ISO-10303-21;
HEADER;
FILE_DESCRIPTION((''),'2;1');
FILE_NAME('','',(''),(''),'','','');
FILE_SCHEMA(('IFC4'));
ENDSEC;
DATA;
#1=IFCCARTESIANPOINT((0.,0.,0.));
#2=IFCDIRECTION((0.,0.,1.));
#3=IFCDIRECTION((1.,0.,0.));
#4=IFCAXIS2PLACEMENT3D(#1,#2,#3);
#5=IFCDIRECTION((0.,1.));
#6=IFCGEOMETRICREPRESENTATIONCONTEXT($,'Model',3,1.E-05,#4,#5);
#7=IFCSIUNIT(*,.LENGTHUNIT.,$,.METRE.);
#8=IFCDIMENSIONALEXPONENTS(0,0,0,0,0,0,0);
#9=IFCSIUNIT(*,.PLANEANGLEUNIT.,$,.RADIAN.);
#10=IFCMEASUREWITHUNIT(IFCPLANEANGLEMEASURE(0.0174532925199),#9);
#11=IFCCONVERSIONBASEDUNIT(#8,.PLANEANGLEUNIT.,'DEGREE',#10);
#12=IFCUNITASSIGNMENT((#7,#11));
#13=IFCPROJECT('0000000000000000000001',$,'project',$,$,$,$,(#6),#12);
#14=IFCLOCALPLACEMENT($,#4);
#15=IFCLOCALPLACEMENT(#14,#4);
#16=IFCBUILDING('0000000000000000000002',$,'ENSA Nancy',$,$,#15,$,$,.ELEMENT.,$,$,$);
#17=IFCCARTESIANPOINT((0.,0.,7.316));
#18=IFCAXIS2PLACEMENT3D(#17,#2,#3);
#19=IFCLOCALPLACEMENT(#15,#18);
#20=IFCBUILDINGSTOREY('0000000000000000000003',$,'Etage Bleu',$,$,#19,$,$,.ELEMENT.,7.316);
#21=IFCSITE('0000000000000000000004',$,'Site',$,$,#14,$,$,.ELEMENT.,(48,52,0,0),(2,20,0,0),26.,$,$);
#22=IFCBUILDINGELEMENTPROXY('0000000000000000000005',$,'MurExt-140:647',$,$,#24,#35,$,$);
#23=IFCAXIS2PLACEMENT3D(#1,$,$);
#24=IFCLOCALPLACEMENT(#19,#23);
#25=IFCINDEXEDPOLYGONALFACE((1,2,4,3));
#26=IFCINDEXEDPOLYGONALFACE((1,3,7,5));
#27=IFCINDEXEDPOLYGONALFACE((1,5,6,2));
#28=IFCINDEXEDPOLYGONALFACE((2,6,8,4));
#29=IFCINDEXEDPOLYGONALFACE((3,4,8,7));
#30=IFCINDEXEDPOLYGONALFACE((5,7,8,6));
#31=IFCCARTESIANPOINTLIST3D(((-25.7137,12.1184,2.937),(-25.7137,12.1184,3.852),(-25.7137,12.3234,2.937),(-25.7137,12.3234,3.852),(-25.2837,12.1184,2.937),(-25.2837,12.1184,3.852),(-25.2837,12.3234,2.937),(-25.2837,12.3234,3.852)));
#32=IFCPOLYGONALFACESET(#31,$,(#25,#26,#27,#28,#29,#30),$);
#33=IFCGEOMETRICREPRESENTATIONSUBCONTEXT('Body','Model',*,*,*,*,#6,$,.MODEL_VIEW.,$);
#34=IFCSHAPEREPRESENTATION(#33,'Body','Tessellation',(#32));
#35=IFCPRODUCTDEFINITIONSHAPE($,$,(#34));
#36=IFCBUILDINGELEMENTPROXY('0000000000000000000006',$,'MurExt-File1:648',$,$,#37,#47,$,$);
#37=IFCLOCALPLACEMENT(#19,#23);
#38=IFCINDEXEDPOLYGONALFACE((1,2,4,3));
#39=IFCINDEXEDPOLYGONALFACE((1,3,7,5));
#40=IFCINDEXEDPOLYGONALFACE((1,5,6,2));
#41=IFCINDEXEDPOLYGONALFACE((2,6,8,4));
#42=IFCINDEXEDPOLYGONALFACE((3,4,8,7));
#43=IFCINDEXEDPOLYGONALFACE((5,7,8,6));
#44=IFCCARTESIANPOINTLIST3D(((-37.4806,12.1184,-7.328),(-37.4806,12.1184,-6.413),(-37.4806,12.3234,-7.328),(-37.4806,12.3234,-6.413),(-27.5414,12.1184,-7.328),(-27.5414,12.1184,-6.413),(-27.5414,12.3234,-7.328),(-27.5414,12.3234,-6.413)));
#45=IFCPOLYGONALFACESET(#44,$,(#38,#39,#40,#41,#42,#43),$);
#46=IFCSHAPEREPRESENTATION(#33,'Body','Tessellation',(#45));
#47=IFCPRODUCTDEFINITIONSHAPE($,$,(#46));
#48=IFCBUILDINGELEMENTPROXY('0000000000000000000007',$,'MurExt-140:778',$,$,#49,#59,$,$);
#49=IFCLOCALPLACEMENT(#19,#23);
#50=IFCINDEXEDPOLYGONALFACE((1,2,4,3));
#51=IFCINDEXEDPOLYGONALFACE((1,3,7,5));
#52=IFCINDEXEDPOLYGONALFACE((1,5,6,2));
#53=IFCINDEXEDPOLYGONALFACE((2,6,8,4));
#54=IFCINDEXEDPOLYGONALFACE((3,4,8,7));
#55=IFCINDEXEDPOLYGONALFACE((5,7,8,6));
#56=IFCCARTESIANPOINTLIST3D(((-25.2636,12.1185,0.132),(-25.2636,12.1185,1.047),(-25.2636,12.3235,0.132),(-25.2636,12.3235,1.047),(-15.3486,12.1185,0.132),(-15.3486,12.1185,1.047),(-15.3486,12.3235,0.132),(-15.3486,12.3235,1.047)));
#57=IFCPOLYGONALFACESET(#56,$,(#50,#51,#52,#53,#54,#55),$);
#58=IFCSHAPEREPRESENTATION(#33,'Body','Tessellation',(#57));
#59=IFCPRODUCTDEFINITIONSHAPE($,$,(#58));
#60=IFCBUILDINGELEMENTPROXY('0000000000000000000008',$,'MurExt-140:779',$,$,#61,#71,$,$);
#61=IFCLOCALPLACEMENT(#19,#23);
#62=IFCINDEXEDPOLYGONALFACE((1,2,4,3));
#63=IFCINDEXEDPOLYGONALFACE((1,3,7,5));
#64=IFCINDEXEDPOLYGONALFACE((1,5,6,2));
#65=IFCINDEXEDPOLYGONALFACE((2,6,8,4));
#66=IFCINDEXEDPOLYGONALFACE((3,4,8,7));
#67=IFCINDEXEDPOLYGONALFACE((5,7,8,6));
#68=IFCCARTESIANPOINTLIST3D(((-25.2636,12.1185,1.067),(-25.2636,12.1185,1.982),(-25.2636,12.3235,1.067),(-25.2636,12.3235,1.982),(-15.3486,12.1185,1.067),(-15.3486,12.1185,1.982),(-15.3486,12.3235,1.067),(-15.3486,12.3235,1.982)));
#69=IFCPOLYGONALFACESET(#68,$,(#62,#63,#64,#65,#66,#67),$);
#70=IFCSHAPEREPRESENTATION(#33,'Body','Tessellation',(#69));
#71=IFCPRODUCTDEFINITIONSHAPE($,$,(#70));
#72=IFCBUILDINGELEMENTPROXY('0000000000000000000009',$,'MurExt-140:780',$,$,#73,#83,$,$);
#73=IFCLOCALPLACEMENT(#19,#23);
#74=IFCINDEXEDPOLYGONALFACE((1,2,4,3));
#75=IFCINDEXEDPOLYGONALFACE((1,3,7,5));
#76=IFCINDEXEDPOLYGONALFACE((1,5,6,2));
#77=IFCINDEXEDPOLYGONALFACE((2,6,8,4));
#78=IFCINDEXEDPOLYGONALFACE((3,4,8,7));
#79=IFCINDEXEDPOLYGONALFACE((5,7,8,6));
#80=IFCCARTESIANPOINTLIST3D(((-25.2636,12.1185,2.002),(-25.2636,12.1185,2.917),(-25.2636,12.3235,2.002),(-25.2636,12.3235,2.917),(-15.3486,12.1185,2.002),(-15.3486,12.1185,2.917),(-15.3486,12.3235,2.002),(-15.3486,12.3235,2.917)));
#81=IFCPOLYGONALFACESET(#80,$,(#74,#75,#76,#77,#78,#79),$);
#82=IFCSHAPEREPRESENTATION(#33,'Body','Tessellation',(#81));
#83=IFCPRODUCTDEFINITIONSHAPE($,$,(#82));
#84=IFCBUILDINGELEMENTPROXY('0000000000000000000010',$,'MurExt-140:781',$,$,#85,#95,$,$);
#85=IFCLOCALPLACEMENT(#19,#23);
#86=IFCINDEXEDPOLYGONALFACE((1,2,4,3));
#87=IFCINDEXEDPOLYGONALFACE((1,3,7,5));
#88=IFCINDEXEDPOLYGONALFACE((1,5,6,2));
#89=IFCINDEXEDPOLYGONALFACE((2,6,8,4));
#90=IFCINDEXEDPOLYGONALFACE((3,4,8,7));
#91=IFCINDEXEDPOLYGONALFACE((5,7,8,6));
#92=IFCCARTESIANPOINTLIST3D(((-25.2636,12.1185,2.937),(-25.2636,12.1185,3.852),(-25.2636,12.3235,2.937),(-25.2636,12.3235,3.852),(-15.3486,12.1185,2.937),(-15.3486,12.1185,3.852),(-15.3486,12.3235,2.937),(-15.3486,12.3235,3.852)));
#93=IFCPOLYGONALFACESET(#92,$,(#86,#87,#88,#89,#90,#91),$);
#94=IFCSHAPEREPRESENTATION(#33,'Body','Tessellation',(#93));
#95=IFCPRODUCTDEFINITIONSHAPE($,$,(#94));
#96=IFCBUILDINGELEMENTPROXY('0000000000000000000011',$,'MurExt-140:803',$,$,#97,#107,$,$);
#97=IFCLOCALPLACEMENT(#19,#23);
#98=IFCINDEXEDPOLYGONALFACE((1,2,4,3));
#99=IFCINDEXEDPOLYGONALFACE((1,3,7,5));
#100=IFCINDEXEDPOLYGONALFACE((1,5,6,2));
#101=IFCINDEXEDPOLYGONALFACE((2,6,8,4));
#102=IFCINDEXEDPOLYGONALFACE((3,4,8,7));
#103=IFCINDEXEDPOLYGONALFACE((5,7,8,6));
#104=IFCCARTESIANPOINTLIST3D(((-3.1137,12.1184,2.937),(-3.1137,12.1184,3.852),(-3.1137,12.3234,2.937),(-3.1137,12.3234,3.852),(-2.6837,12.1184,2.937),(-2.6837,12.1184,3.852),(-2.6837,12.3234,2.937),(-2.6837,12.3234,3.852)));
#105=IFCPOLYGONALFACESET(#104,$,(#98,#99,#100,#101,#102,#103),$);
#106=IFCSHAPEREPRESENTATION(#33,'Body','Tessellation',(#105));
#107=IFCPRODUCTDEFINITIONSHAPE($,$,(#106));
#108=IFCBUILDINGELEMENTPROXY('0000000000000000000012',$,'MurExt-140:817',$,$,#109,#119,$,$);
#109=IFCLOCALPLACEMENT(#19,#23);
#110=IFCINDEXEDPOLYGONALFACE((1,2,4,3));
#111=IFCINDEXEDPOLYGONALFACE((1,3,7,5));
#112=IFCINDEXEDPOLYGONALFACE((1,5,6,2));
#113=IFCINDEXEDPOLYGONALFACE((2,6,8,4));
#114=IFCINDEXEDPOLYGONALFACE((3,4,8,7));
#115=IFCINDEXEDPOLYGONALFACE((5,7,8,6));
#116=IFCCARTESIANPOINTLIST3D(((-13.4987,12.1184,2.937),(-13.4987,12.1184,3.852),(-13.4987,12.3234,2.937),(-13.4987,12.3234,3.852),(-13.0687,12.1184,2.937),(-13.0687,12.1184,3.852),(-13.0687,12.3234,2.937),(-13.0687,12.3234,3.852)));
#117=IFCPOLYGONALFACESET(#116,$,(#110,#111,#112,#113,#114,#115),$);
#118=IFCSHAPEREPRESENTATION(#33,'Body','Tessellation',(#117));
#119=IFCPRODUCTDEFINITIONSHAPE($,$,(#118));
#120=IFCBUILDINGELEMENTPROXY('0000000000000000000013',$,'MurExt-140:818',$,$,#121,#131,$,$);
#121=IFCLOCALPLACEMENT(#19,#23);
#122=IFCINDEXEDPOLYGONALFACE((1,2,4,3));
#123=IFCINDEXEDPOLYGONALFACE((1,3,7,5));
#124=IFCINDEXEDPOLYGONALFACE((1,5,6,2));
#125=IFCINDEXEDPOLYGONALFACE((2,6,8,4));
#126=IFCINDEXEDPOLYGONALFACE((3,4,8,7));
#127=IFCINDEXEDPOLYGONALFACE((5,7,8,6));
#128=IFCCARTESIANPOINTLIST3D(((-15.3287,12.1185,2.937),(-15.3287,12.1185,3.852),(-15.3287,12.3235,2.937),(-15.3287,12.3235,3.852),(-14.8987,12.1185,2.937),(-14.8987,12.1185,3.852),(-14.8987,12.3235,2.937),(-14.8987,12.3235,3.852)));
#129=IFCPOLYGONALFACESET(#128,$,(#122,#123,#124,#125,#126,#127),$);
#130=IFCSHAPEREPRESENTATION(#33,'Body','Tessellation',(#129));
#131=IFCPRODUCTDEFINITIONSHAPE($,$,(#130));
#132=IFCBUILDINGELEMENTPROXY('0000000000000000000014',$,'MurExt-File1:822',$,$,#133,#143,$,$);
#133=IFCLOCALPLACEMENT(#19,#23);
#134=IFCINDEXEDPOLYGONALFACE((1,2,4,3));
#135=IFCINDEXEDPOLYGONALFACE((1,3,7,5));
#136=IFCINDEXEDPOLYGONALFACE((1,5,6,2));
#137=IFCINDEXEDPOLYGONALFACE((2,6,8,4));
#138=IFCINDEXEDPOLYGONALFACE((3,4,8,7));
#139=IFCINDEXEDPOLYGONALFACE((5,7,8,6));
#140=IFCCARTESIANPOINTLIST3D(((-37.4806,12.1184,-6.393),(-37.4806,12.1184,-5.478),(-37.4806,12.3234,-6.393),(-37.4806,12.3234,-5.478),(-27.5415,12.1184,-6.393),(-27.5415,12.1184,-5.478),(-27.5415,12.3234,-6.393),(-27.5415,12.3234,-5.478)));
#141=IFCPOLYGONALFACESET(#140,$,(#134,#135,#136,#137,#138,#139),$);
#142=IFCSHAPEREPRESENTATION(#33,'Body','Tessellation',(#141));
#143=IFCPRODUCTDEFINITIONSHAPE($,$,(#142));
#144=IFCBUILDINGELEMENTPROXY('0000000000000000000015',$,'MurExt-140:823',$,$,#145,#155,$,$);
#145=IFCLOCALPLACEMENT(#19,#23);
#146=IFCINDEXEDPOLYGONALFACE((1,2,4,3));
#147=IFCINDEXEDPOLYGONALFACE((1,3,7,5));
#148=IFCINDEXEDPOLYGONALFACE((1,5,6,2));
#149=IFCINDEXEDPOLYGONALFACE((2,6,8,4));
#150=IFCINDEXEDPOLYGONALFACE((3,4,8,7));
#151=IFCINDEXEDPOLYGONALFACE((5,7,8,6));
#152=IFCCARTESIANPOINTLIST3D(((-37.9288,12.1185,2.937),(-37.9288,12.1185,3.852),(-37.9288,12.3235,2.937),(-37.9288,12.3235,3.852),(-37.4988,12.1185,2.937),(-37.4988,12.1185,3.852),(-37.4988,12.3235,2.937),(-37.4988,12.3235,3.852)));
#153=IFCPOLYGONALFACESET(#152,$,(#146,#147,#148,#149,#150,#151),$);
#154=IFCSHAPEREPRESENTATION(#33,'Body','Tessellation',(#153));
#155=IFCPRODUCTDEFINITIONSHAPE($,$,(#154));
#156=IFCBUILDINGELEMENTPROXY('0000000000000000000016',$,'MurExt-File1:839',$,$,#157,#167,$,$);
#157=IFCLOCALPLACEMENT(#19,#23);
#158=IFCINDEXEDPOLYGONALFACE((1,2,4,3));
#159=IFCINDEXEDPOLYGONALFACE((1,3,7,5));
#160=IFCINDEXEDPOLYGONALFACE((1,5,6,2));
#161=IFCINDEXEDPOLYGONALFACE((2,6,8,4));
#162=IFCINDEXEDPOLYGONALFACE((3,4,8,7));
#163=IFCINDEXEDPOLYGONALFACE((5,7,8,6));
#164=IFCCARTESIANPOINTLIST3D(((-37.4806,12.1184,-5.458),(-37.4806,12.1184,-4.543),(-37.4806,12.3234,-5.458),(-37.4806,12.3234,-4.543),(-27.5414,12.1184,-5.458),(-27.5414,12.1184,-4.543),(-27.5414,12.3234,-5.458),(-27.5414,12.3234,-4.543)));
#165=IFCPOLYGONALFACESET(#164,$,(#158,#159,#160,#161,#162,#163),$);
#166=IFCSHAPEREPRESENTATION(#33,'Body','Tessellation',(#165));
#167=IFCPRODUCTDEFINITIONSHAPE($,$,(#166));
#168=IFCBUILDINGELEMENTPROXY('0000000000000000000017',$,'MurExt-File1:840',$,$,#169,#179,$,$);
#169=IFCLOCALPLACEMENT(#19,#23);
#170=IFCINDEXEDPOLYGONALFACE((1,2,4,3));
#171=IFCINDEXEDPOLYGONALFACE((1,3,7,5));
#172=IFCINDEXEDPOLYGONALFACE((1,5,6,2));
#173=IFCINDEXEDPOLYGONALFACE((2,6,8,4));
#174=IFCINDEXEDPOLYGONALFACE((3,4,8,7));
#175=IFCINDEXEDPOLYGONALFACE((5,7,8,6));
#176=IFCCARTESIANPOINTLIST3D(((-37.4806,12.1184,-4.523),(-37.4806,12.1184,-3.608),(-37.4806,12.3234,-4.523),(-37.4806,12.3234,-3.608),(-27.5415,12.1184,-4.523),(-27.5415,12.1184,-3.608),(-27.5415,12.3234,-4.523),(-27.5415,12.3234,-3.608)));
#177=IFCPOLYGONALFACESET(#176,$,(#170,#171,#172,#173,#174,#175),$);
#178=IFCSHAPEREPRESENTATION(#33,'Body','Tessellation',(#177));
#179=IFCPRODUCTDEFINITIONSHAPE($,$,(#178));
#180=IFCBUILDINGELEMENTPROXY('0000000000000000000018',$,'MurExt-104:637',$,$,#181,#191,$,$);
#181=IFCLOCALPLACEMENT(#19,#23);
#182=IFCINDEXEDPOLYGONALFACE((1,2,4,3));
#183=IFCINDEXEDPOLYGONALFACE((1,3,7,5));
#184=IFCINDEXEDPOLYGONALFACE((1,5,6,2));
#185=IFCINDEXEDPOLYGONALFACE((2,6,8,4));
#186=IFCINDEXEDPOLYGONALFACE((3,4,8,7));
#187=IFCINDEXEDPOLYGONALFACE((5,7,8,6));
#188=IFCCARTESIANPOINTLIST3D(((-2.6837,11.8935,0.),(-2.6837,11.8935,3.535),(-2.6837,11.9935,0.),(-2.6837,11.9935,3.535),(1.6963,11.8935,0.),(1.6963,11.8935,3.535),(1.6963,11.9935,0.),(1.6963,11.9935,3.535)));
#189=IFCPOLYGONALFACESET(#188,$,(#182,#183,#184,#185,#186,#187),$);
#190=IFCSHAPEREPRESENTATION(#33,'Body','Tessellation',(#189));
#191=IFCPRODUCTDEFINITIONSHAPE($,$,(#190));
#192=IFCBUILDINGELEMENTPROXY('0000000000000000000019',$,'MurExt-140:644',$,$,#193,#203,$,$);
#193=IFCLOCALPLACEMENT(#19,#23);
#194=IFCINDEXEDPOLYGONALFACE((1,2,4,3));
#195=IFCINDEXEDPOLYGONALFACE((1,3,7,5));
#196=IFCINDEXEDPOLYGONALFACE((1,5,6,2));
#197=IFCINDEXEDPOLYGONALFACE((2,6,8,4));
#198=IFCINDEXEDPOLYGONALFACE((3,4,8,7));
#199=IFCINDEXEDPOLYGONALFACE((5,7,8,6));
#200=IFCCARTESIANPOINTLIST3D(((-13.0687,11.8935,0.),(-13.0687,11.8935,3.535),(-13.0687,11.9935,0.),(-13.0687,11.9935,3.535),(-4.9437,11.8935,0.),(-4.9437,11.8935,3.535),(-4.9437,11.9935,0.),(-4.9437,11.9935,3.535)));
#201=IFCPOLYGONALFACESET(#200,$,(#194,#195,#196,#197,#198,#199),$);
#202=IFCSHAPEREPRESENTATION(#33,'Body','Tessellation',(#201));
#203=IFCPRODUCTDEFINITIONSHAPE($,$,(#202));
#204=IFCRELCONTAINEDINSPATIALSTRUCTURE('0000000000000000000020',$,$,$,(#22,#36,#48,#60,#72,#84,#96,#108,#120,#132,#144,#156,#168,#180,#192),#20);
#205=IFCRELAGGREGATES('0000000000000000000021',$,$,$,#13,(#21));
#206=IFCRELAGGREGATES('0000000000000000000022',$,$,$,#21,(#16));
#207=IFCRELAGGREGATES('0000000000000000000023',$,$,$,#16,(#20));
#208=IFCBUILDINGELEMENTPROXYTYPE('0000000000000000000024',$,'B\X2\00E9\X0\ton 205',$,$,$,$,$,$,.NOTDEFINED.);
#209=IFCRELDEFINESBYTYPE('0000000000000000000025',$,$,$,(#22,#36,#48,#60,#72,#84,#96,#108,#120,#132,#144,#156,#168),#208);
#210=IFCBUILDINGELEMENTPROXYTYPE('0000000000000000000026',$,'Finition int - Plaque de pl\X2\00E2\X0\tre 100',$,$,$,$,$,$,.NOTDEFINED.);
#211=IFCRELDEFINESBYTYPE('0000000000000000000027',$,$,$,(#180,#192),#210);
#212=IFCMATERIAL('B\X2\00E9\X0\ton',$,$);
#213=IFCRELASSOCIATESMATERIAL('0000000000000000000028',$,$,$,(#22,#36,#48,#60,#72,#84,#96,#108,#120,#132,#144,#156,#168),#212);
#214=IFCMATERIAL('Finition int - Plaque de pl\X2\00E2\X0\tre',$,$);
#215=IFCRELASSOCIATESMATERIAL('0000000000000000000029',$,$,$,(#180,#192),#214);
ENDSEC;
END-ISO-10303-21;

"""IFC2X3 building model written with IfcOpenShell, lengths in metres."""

from ifc_helpers import new_model, entity, si_unit, converted_unit, direction, frame, origin_with_axes, place, context, subcontext, project, spatial, polyline, outline, extrude, material, type_object, element, save


model = new_model("IFC2X3")

# Units and contexts
model_context = context("Model", 3, precision=1e-05, world=origin_with_axes(), true_north=direction((0.0, 1.0)))
body_context = subcontext(model_context, "Body", "Model", "MODEL_VIEW")
ifc_project = project(units=[si_unit("LENGTHUNIT", "METRE"), converted_unit("PLANEANGLEUNIT", "DEGREE", entity("IfcPlaneAngleMeasure", 0.0174532925199), si_unit("PLANEANGLEUNIT", "RADIAN"), dimensions=[0, 0, 0, 0, 0, 0, 0])], contexts=[model_context])

# Site, building, storey
site_placement = place(None, origin_with_axes())
site = spatial("IfcSite", under=ifc_project, at=site_placement, Name="Site", CompositionType="ELEMENT", RefLatitude=(48, 52, 0, 0), RefLongitude=(2, 20, 0, 0), RefElevation=26.0)
building_placement = place(site_placement, origin_with_axes())
building = spatial("IfcBuilding", under=site, at=building_placement, Name="ENSA Nancy", CompositionType="ELEMENT")
storey_placement = place(building_placement, frame((0.0, 0.0, 7.316), z_axis=(0.0, 0.0, 1.0), x_axis=(1.0, 0.0, 0.0)))
storey = spatial("IfcBuildingStorey", under=building, at=storey_placement, Name="Etage Bleu", CompositionType="ELEMENT", Elevation=7.316)

# Shared definitions
ifc_material_1 = material(Name="Finition int - Plaque de plâtre")

# Shared definitions
ifc_material_2 = material(Name="Béton")

# Building element proxies
building_element_proxy_type_1 = type_object("IfcBuildingElementProxyType", Name="Béton 205", PredefinedType="NOTDEFINED")
for number, where, z_axis, x_axis, name in (
    (1, (-25.7137, 12.3234, 2.937), (0.0, 0.0, 1.0), (1.0, 0.0, 0.0), "MurExt-140:647"),
):
    element("IfcBuildingElementProxy", number, at=place(storey_placement, frame(where, z_axis=z_axis, x_axis=x_axis)), inside=storey, type_object=building_element_proxy_type_1, material=ifc_material_2, Name=name, context=body_context, shape_type="SweptSolid", body=[
        extrude(outline(polyline([(0.0, -0.205), (0.43, -0.205), (0.43, 0.0), (0.0, 0.0), (0.0, -0.205)])), origin_with_axes(), (0.0, 0.0, 1.0), 0.915),
    ])
proxy_1_placement = place(storey_placement, frame((-37.4806, 12.3234, -7.328), z_axis=(0.0, 0.0, 1.0), x_axis=(1.0, -0.000005, 0.0)))
element("IfcBuildingElementProxy", 2, at=proxy_1_placement, inside=storey, type_object=building_element_proxy_type_1, material=ifc_material_2, Name="MurExt-File1:648", context=body_context, shape_type="SweptSolid", body=[
    extrude(outline(polyline([(0.0, -0.205), (9.9392, -0.205), (9.9392, 0.0), (0.0, 0.0), (0.0, -0.205)])), origin_with_axes(), (0.0, 0.0, 1.0), 0.915),
])
for number, where, z_axis, x_axis, name in (
    (3, (-25.2636, 12.3235, 0.132), (0.0, 0.0, 1.0), (1.0, 0.0, 0.0), "MurExt-140:778"),
    (4, (-25.2636, 12.3235, 1.067), (0.0, 0.0, 1.0), (1.0, 0.0, 0.0), "MurExt-140:779"),
    (5, (-25.2636, 12.3235, 2.002), (0.0, 0.0, 1.0), (1.0, 0.0, 0.0), "MurExt-140:780"),
    (6, (-25.2636, 12.3235, 2.937), (0.0, 0.0, 1.0), (1.0, 0.0, 0.0), "MurExt-140:781"),
):
    element("IfcBuildingElementProxy", number, at=place(storey_placement, frame(where, z_axis=z_axis, x_axis=x_axis)), inside=storey, type_object=building_element_proxy_type_1, material=ifc_material_2, Name=name, context=body_context, shape_type="SweptSolid", body=[
        extrude(outline(polyline([(0.0, -0.205), (9.915, -0.205), (9.915, 0.0), (0.0, 0.0), (0.0, -0.205)])), origin_with_axes(), (0.0, 0.0, 1.0), 0.915),
    ])
for number, where, z_axis, x_axis, name in (
    (7, (-3.1137, 12.3234, 2.937), (0.0, 0.0, 1.0), (1.0, 0.0, 0.0), "MurExt-140:803"),
    (8, (-13.4987, 12.3234, 2.937), (0.0, 0.0, 1.0), (1.0, 0.0, 0.0), "MurExt-140:817"),
    (9, (-15.3287, 12.3235, 2.937), (0.0, 0.0, 1.0), (1.0, 0.0, 0.0), "MurExt-140:818"),
):
    element("IfcBuildingElementProxy", number, at=place(storey_placement, frame(where, z_axis=z_axis, x_axis=x_axis)), inside=storey, type_object=building_element_proxy_type_1, material=ifc_material_2, Name=name, context=body_context, shape_type="SweptSolid", body=[
        extrude(outline(polyline([(0.0, -0.205), (0.43, -0.205), (0.43, 0.0), (0.0, 0.0), (0.0, -0.205)])), origin_with_axes(), (0.0, 0.0, 1.0), 0.915),
    ])
proxy_2_placement = place(storey_placement, frame((-37.4806, 12.3234, -6.393), z_axis=(0.0, 0.0, 1.0), x_axis=(1.0, -0.000005, 0.0)))
element("IfcBuildingElementProxy", 10, at=proxy_2_placement, inside=storey, type_object=building_element_proxy_type_1, material=ifc_material_2, Name="MurExt-File1:822", context=body_context, shape_type="SweptSolid", body=[
    extrude(outline(polyline([(0.0, -0.205), (9.9392, -0.205), (9.9392, 0.0), (0.0, 0.0), (0.0, -0.205)])), origin_with_axes(), (0.0, 0.0, 1.0), 0.915),
])
proxy_3_placement = place(storey_placement, frame((-37.9288, 12.3235, 2.937), z_axis=(0.0, 0.0, 1.0), x_axis=(1.0, 0.0, 0.0)))
element("IfcBuildingElementProxy", 11, at=proxy_3_placement, inside=storey, type_object=building_element_proxy_type_1, material=ifc_material_2, Name="MurExt-140:823", context=body_context, shape_type="SweptSolid", body=[
    extrude(outline(polyline([(0.0, -0.205), (0.43, -0.205), (0.43, 0.0), (0.0, 0.0), (0.0, -0.205)])), origin_with_axes(), (0.0, 0.0, 1.0), 0.915),
])
for number, where, z_axis, x_axis, name in (
    (12, (-37.4806, 12.3234, -5.458), (0.0, 0.0, 1.0), (1.0, -0.000005, 0.0), "MurExt-File1:839"),
    (13, (-37.4806, 12.3234, -4.523), (0.0, 0.0, 1.0), (1.0, -0.000005, 0.0), "MurExt-File1:840"),
):
    element("IfcBuildingElementProxy", number, at=place(storey_placement, frame(where, z_axis=z_axis, x_axis=x_axis)), inside=storey, type_object=building_element_proxy_type_1, material=ifc_material_2, Name=name, context=body_context, shape_type="SweptSolid", body=[
        extrude(outline(polyline([(0.0, -0.205), (9.9392, -0.205), (9.9392, 0.0), (0.0, 0.0), (0.0, -0.205)])), origin_with_axes(), (0.0, 0.0, 1.0), 0.915),
    ])
building_element_proxy_type_2 = type_object("IfcBuildingElementProxyType", Name="Finition int - Plaque de plâtre 100", PredefinedType="NOTDEFINED")
proxy_4_placement = place(storey_placement, frame((-2.6837, 11.8935, 0.0), z_axis=(0.0, 0.0, 1.0), x_axis=(1.0, 0.0, 0.0)))
element("IfcBuildingElementProxy", 14, at=proxy_4_placement, inside=storey, type_object=building_element_proxy_type_2, material=ifc_material_1, Name="MurExt-104:637", context=body_context, shape_type="SweptSolid", body=[
    extrude(outline(polyline([(0.0, 0.0), (4.38, 0.0), (4.38, 0.1), (0.0, 0.1), (0.0, 0.0)])), origin_with_axes(), (0.0, 0.0, 1.0), 3.535),
])
proxy_5_placement = place(storey_placement, frame((-13.0687, 11.8935, 0.0), z_axis=(0.0, 0.0, 1.0), x_axis=(1.0, 0.0, 0.0)))
element("IfcBuildingElementProxy", 15, at=proxy_5_placement, inside=storey, type_object=building_element_proxy_type_2, material=ifc_material_1, Name="MurExt-140:644", context=body_context, shape_type="SweptSolid", body=[
    extrude(outline(polyline([(0.0, 0.0), (8.125, 0.0), (8.125, 0.1), (0.0, 0.1), (0.0, 0.0)])), origin_with_axes(), (0.0, 0.0, 1.0), 3.535),
])

save(model, "model.ifc")
